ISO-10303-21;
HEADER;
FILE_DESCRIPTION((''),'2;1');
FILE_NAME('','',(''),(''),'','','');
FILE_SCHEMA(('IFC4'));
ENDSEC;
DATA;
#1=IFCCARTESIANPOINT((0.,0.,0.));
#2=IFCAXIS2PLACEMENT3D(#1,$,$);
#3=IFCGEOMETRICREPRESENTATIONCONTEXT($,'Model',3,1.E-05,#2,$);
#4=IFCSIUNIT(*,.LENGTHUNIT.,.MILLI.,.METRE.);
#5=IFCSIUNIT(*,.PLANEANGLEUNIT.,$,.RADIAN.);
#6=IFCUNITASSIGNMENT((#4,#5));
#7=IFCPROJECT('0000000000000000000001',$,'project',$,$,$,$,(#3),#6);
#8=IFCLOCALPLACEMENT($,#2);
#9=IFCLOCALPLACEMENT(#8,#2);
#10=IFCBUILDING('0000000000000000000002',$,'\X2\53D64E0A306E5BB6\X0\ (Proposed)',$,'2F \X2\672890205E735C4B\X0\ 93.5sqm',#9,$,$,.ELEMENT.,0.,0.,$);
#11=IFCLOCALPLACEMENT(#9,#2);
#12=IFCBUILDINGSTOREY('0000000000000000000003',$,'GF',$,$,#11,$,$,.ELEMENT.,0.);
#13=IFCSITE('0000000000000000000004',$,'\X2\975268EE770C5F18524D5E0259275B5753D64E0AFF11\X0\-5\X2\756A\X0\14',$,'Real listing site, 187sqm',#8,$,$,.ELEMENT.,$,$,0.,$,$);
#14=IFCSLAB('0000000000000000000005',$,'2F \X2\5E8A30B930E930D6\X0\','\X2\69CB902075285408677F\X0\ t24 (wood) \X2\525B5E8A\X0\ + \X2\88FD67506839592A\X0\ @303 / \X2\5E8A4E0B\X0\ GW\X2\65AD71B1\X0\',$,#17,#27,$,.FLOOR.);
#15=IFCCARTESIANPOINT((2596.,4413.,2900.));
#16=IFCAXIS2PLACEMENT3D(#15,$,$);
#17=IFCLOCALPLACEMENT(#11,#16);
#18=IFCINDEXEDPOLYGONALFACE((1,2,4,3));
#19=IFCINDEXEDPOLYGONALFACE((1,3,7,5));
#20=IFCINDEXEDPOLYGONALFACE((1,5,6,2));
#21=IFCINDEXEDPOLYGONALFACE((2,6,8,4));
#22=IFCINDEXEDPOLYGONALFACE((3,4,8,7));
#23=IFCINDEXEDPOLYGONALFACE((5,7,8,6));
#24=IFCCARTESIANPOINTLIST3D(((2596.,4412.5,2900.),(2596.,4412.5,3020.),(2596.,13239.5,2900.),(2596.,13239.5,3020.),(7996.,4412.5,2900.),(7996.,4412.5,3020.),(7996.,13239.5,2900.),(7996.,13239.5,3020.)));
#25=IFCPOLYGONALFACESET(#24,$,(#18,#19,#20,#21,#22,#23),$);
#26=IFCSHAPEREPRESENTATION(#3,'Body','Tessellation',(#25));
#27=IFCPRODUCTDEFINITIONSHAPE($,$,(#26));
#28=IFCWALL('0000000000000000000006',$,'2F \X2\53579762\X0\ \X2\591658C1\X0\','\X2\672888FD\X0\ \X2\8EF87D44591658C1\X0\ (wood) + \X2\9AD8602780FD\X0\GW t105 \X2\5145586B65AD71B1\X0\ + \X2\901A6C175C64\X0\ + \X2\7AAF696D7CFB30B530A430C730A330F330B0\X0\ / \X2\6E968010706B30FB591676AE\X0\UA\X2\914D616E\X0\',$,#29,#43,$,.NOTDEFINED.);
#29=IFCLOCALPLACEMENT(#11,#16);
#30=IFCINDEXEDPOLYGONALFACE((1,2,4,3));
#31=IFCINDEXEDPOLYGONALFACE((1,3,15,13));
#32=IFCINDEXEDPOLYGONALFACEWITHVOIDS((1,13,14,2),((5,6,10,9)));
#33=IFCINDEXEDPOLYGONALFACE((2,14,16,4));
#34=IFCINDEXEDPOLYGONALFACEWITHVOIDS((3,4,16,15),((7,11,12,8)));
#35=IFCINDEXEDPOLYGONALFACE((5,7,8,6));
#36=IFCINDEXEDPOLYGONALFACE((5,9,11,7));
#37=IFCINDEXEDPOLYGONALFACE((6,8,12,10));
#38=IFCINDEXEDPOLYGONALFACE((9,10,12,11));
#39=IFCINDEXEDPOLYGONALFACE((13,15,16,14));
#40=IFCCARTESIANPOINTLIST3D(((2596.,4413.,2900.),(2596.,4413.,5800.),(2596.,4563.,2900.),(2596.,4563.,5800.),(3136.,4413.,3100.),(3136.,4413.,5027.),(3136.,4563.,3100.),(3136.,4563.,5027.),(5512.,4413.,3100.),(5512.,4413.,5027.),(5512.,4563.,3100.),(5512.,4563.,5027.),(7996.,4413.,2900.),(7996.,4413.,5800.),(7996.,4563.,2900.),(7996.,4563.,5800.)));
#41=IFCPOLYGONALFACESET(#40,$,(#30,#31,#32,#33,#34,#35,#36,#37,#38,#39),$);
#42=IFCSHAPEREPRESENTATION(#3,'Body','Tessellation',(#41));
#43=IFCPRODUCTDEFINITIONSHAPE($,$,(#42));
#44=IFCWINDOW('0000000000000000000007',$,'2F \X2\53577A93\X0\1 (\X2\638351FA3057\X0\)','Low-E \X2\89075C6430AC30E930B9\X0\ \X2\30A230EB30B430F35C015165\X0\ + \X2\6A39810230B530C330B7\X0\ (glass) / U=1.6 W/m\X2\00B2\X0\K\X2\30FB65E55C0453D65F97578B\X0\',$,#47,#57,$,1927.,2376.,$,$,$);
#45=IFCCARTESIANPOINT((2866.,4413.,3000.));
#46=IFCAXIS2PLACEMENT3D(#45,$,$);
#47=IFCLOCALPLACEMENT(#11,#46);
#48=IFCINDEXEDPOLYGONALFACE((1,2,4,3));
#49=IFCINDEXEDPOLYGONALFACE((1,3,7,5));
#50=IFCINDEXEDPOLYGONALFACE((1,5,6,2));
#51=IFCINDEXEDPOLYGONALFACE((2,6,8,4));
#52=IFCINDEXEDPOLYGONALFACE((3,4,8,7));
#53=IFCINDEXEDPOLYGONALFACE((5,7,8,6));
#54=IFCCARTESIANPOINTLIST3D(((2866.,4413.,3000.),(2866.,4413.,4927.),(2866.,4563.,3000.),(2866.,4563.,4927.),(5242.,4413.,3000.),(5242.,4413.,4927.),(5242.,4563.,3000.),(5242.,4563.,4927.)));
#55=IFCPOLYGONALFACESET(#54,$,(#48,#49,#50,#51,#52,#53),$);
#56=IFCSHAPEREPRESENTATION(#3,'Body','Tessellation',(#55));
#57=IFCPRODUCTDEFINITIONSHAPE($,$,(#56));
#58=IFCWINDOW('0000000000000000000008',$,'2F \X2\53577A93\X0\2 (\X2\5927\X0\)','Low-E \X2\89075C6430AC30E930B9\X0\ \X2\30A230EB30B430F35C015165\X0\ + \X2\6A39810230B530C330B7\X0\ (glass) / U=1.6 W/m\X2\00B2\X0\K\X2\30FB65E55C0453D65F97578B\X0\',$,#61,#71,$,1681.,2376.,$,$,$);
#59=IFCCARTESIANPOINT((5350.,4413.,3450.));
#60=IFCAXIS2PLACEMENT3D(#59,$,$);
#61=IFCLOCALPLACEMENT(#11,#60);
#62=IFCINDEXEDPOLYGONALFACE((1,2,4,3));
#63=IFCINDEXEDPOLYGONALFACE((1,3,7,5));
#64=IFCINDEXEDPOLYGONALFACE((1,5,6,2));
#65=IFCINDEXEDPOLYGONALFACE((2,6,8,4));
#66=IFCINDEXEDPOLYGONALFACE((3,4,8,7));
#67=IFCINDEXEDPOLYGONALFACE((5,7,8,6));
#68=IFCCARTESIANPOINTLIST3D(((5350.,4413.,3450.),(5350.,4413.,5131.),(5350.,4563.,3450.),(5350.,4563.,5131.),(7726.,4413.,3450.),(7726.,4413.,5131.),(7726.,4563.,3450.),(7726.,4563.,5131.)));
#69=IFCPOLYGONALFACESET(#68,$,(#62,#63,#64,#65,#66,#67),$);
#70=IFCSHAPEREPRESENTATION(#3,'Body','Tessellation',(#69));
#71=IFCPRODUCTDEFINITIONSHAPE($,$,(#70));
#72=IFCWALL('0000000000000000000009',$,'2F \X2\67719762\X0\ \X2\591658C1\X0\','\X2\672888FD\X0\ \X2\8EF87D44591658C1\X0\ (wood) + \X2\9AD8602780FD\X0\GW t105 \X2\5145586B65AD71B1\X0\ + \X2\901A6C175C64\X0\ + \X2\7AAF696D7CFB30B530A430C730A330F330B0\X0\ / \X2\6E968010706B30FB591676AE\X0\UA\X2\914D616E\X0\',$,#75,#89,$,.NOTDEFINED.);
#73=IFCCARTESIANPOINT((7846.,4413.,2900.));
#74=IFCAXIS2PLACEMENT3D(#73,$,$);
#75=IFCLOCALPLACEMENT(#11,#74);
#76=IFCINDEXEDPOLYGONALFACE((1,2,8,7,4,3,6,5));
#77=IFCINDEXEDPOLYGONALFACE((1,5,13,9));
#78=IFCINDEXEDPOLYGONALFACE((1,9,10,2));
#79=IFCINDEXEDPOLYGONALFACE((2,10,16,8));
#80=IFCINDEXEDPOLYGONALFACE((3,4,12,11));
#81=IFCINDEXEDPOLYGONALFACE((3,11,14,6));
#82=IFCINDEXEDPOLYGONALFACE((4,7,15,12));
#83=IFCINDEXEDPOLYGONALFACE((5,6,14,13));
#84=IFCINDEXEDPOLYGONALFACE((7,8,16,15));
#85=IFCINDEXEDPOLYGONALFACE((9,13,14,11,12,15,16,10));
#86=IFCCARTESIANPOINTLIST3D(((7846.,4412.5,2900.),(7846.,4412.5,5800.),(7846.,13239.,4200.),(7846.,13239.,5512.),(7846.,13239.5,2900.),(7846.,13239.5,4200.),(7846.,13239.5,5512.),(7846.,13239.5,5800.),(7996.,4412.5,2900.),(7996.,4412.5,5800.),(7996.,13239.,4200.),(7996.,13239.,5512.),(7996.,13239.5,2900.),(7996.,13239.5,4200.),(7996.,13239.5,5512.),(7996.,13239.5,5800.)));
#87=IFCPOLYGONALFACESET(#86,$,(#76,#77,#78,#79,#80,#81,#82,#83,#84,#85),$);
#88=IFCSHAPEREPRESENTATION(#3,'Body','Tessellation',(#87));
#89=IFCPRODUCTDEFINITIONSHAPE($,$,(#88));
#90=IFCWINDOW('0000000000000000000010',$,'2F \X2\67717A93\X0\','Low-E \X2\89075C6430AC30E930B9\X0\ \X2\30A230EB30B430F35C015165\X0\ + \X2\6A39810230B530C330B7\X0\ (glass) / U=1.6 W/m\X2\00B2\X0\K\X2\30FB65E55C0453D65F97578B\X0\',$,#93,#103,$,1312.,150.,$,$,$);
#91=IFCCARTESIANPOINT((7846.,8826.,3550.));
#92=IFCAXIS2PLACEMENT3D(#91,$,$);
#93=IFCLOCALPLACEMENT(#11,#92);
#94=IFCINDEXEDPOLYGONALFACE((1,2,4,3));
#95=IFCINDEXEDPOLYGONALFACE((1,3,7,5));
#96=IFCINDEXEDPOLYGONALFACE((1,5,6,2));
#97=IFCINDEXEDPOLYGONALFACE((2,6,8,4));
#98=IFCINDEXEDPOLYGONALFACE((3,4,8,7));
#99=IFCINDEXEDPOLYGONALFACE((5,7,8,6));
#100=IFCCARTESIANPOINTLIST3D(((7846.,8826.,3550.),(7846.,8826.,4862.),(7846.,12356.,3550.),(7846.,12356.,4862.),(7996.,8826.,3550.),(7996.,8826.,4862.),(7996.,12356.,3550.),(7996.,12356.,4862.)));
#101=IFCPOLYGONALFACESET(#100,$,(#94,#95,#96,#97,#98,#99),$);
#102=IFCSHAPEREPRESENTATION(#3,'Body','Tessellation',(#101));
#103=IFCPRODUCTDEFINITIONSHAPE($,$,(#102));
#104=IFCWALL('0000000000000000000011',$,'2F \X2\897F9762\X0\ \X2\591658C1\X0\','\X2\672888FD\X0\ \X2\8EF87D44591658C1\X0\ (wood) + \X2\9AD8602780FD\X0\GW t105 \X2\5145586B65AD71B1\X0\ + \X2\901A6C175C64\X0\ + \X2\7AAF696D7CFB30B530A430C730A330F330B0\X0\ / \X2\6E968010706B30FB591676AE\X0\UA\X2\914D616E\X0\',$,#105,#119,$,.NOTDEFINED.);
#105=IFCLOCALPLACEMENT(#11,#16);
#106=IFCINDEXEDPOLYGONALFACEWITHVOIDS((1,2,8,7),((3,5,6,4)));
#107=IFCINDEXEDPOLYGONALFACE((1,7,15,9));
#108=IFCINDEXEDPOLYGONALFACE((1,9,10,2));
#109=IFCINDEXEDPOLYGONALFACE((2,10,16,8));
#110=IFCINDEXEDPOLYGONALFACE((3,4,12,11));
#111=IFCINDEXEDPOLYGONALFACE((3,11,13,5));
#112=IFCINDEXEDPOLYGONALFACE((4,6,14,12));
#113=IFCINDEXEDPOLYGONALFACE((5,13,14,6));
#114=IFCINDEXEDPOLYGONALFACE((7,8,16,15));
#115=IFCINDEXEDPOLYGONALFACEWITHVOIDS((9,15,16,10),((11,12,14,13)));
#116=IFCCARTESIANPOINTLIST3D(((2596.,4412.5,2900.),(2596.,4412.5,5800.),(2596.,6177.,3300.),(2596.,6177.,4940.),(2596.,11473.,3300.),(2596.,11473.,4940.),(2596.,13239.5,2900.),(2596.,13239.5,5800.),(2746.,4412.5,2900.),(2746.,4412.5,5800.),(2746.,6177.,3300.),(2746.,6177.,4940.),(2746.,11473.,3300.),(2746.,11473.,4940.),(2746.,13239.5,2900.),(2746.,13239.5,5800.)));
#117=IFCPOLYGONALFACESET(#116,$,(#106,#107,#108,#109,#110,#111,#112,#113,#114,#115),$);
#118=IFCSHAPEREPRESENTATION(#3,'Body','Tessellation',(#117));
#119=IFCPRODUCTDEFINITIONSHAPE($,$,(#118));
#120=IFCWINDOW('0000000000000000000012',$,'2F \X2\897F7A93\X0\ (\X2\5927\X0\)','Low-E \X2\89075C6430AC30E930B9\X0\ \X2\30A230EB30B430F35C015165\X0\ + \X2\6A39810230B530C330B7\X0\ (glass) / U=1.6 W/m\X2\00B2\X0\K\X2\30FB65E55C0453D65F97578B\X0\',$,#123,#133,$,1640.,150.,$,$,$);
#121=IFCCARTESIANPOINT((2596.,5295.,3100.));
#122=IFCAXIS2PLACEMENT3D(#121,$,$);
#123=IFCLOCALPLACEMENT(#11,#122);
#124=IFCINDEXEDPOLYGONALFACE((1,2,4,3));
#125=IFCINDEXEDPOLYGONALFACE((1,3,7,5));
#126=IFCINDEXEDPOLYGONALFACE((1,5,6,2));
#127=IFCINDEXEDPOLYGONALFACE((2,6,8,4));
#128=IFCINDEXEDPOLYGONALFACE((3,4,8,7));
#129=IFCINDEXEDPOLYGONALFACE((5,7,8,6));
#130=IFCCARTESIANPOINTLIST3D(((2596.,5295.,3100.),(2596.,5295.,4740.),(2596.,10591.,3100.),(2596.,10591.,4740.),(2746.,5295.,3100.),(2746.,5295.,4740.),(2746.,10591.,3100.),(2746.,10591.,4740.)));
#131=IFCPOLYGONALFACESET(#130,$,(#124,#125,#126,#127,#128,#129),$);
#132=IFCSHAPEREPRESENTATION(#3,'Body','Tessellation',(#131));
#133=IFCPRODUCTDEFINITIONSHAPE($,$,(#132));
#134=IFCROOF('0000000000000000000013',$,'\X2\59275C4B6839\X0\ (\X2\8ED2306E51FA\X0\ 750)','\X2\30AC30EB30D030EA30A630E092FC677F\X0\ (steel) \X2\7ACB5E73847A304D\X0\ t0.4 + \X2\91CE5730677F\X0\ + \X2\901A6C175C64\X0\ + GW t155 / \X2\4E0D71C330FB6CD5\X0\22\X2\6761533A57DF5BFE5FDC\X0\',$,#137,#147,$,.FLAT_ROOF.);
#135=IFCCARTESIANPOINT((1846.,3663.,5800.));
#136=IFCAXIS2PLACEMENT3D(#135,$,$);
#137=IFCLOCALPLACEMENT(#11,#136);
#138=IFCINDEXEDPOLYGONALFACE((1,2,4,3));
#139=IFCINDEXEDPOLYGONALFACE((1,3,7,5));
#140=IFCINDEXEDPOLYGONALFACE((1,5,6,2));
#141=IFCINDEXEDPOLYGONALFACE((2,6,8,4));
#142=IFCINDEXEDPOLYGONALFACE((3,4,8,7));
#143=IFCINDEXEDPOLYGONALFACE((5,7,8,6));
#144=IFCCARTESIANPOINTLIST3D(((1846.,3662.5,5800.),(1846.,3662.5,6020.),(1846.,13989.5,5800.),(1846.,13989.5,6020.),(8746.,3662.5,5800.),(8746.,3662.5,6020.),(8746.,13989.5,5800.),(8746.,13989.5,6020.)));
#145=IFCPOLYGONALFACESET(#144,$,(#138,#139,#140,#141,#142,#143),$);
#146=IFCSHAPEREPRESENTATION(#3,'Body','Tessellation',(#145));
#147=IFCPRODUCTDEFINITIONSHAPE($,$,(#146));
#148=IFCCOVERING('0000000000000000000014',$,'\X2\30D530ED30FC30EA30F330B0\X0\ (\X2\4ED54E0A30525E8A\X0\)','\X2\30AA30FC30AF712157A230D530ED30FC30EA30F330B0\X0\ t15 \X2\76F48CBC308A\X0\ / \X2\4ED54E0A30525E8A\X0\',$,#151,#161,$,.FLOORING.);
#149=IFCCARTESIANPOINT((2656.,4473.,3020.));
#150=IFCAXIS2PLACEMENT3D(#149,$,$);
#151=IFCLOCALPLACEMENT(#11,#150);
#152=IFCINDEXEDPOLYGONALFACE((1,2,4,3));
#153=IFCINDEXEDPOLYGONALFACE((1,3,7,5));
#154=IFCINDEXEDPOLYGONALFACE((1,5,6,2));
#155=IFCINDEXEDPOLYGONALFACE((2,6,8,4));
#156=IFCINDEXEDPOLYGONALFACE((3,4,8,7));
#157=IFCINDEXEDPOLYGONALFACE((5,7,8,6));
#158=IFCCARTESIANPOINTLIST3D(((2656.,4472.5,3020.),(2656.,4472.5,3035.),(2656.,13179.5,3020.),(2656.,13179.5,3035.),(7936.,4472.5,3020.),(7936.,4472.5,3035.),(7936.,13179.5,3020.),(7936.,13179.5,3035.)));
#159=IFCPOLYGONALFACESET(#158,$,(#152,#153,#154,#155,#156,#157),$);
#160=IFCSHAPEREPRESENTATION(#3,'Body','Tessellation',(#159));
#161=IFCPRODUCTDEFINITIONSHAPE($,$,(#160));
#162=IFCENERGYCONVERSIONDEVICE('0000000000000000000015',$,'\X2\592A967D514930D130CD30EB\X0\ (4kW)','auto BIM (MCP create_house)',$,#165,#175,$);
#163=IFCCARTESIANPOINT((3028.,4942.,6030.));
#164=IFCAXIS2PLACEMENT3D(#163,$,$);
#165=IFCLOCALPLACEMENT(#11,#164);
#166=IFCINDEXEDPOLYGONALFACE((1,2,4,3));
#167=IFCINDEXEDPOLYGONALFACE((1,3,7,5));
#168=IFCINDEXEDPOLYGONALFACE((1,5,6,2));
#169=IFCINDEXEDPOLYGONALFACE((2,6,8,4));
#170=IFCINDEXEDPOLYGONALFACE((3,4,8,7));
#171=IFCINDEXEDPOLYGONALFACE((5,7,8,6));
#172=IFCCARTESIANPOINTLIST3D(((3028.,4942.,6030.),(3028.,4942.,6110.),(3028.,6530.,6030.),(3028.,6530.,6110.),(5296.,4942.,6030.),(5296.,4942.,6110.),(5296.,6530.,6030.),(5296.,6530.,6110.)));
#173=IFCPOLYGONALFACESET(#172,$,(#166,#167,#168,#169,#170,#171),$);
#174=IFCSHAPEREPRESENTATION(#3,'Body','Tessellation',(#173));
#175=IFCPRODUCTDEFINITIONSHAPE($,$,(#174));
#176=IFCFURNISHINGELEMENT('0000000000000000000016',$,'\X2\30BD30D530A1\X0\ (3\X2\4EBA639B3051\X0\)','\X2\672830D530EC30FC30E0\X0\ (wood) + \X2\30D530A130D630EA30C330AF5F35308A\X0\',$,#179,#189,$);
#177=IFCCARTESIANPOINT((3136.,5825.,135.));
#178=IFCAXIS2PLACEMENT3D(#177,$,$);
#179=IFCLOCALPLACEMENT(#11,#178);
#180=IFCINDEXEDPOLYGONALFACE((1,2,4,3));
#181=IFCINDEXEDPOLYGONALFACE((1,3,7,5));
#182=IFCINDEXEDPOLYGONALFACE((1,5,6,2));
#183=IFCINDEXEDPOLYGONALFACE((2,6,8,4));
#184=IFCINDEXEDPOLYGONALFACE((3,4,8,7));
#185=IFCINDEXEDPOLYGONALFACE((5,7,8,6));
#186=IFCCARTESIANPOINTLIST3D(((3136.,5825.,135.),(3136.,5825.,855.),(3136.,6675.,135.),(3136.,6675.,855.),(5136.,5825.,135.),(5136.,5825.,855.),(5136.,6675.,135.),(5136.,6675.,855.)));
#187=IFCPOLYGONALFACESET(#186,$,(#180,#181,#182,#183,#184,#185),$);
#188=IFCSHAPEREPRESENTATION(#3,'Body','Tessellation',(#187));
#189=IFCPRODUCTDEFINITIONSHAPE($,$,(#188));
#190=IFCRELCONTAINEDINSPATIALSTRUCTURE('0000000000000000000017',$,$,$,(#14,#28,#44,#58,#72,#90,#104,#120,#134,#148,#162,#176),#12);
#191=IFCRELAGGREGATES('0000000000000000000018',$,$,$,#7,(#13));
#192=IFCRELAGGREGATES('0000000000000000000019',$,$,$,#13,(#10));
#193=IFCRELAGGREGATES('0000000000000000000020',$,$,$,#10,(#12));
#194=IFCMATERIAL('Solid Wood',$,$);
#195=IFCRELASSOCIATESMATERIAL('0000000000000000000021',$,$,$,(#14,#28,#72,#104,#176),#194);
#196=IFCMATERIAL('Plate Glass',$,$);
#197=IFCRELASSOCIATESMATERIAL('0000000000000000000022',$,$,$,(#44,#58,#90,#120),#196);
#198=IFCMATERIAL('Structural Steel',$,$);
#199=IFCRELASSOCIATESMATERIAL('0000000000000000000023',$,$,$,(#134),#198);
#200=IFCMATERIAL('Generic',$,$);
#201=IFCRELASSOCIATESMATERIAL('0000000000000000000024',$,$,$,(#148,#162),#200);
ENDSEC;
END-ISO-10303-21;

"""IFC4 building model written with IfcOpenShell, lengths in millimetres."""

from ifc_helpers import new_model, si_unit, frame, frame_2d, origin, place, context, project, spatial, rectangle, extrude, material, element, fill, save


model = new_model("IFC4")

# Units and contexts
model_context = context("Model", 3, precision=1e-05, world=origin())
ifc_project = project(units=[si_unit("LENGTHUNIT", "METRE", prefix="MILLI"), si_unit("PLANEANGLEUNIT", "RADIAN")], contexts=[model_context])

# Site, building, storey
site_placement = place(None, origin())
site = spatial("IfcSite", under=ifc_project, at=site_placement, Name="青森県弘前市大字取上１-5番14", ObjectType="Real listing site, 187sqm", CompositionType="ELEMENT", RefElevation=0.0)
building_placement = place(site_placement, origin())
building = spatial("IfcBuilding", under=site, at=building_placement, Name="取上の家 (Proposed)", ObjectType="2F 木造平屋 93.5sqm", CompositionType="ELEMENT", ElevationOfRefHeight=0.0, ElevationOfTerrain=0.0)
storey_placement = place(building_placement, origin())
storey = spatial("IfcBuildingStorey", under=building, at=storey_placement, Name="GF", CompositionType="ELEMENT", Elevation=0.0)

# Slab
ifc_material_1 = material(Name="Solid Wood")
slab_placement = place(storey_placement, frame((2596.0, 4413.0, 2900.0)))
element("IfcSlab", 1, at=slab_placement, inside=storey, material=ifc_material_1, Name="2F 床スラブ", Description="構造用合板 t24 (wood) 剛床 + 製材根太 @303 / 床下 GW断熱", PredefinedType="FLOOR", context=model_context, shape_type="SweptSolid", body=[
    extrude(rectangle(XDim=5400.0, YDim=8827.0, at=frame_2d((2700.0, 4413.0))), frame((2596.0, 4413.0, 2900.0)), (0.0, 0.0, 1.0), 120.0),
])

# Wall, openings, windows
wall_1_placement = place(storey_placement, frame((2596.0, 4413.0, 2900.0)))
wall_1 = element("IfcWall", 2, at=wall_1_placement, inside=storey, material=ifc_material_1, Name="2F 南面 外壁", Description="木製 軸組外壁 (wood) + 高性能GW t105 充填断熱 + 通気層 + 窯業系サイディング / 準耐火・外皮UA配慮", PredefinedType="NOTDEFINED", context=model_context, shape_type="SweptSolid", body=[
    extrude(rectangle(XDim=5400.0, YDim=150.0, at=frame_2d((2700.0, 75.0))), frame((2596.0, 4413.0, 2900.0)), (0.0, 0.0, 1.0), 2900.0),
])
opening_1_placement = place(storey_placement, frame((2866.0, 4413.0, 3000.0)))
opening_1 = element("IfcOpeningElement", 3, at=opening_1_placement, cuts=wall_1, PredefinedType="NOTDEFINED", context=model_context, shape_type="SweptSolid", body=[
    extrude(rectangle(XDim=2376.0, YDim=150.0, at=frame_2d((1188.0, 75.0))), frame((2866.0, 4413.0, 3000.0)), (0.0, 0.0, 1.0), 1927.0),
])
opening_2_placement = place(storey_placement, frame((5350.0, 4413.0, 3450.0)))
opening_2 = element("IfcOpeningElement", 4, at=opening_2_placement, cuts=wall_1, PredefinedType="NOTDEFINED", context=model_context, shape_type="SweptSolid", body=[
    extrude(rectangle(XDim=2376.0, YDim=150.0, at=frame_2d((1188.0, 75.0))), frame((5350.0, 4413.0, 3450.0)), (0.0, 0.0, 1.0), 1681.0),
])
ifc_material_2 = material(Name="Plate Glass")
window_1_placement = place(storey_placement, frame((2866.0, 4413.0, 3000.0)))
window_1 = element("IfcWindow", 5, at=window_1_placement, inside=storey, material=ifc_material_2, Name="2F 南窓1 (掃出し)", Description="Low-E 複層ガラス アルゴン封入 + 樹脂サッシ (glass) / U=1.6 W/m²K・日射取得型", OverallHeight=1927.0, OverallWidth=2376.0, context=model_context, shape_type="SweptSolid", body=[
    extrude(rectangle(XDim=2376.0, YDim=150.0, at=frame_2d((1188.0, 75.0))), frame((2866.0, 4413.0, 3000.0)), (0.0, 0.0, 1.0), 1927.0),
])
fill(opening_1, window_1)
window_2_placement = place(storey_placement, frame((5350.0, 4413.0, 3450.0)))
window_2 = element("IfcWindow", 6, at=window_2_placement, inside=storey, material=ifc_material_2, Name="2F 南窓2 (大)", Description="Low-E 複層ガラス アルゴン封入 + 樹脂サッシ (glass) / U=1.6 W/m²K・日射取得型", OverallHeight=1681.0, OverallWidth=2376.0, context=model_context, shape_type="SweptSolid", body=[
    extrude(rectangle(XDim=2376.0, YDim=150.0, at=frame_2d((1188.0, 75.0))), frame((5350.0, 4413.0, 3450.0)), (0.0, 0.0, 1.0), 1681.0),
])
fill(opening_2, window_2)

# Walls, openings, windows
wall_2_placement = place(storey_placement, frame((7846.0, 4413.0, 2900.0)))
wall_2 = element("IfcWall", 7, at=wall_2_placement, inside=storey, material=ifc_material_1, Name="2F 東面 外壁", Description="木製 軸組外壁 (wood) + 高性能GW t105 充填断熱 + 通気層 + 窯業系サイディング / 準耐火・外皮UA配慮", PredefinedType="NOTDEFINED", context=model_context, shape_type="SweptSolid", body=[
    extrude(rectangle(XDim=150.0, YDim=8827.0, at=frame_2d((75.0, 4413.0))), frame((7846.0, 4413.0, 2900.0)), (0.0, 0.0, 1.0), 2900.0),
])
opening_3_placement = place(storey_placement, frame((7846.0, 8826.0, 3550.0)))
opening_3 = element("IfcOpeningElement", 8, at=opening_3_placement, cuts=wall_2, PredefinedType="NOTDEFINED", context=model_context, shape_type="SweptSolid", body=[
    extrude(rectangle(XDim=150.0, YDim=3530.0, at=frame_2d((75.0, 1765.0))), frame((7846.0, 8826.0, 3550.0)), (0.0, 0.0, 1.0), 1312.0),
])
window_3_placement = place(storey_placement, frame((7846.0, 8826.0, 3550.0)))
window_3 = element("IfcWindow", 9, at=window_3_placement, inside=storey, material=ifc_material_2, Name="2F 東窓", Description="Low-E 複層ガラス アルゴン封入 + 樹脂サッシ (glass) / U=1.6 W/m²K・日射取得型", OverallHeight=1312.0, OverallWidth=150.0, context=model_context, shape_type="SweptSolid", body=[
    extrude(rectangle(XDim=150.0, YDim=3530.0, at=frame_2d((75.0, 1765.0))), frame((7846.0, 8826.0, 3550.0)), (0.0, 0.0, 1.0), 1312.0),
])
fill(opening_3, window_3)
wall_3_placement = place(storey_placement, frame((2596.0, 4413.0, 2900.0)))
wall_3 = element("IfcWall", 10, at=wall_3_placement, inside=storey, material=ifc_material_1, Name="2F 西面 外壁", Description="木製 軸組外壁 (wood) + 高性能GW t105 充填断熱 + 通気層 + 窯業系サイディング / 準耐火・外皮UA配慮", PredefinedType="NOTDEFINED", context=model_context, shape_type="SweptSolid", body=[
    extrude(rectangle(XDim=150.0, YDim=8827.0, at=frame_2d((75.0, 4413.0))), frame((2596.0, 4413.0, 2900.0)), (0.0, 0.0, 1.0), 2900.0),
])
opening_4_placement = place(storey_placement, frame((2596.0, 5295.0, 3100.0)))
opening_4 = element("IfcOpeningElement", 11, at=opening_4_placement, cuts=wall_3, PredefinedType="NOTDEFINED", context=model_context, shape_type="SweptSolid", body=[
    extrude(rectangle(XDim=150.0, YDim=5296.0, at=frame_2d((75.0, 2648.0))), frame((2596.0, 5295.0, 3100.0)), (0.0, 0.0, 1.0), 1640.0),
])
window_4_placement = place(storey_placement, frame((2596.0, 5295.0, 3100.0)))
window_4 = element("IfcWindow", 12, at=window_4_placement, inside=storey, material=ifc_material_2, Name="2F 西窓 (大)", Description="Low-E 複層ガラス アルゴン封入 + 樹脂サッシ (glass) / U=1.6 W/m²K・日射取得型", OverallHeight=1640.0, OverallWidth=150.0, context=model_context, shape_type="SweptSolid", body=[
    extrude(rectangle(XDim=150.0, YDim=5296.0, at=frame_2d((75.0, 2648.0))), frame((2596.0, 5295.0, 3100.0)), (0.0, 0.0, 1.0), 1640.0),
])
fill(opening_4, window_4)

# Roof
ifc_material_3 = material(Name="Structural Steel")
roof_placement = place(storey_placement, frame((1846.0, 3663.0, 5800.0)))
element("IfcRoof", 13, at=roof_placement, inside=storey, material=ifc_material_3, Name="大屋根 (軒の出 750)", Description="ガルバリウム鋼板 (steel) 立平葺き t0.4 + 野地板 + 通気層 + GW t155 / 不燃・法22条区域対応", PredefinedType="FLAT_ROOF", context=model_context, shape_type="SweptSolid", body=[
    extrude(rectangle(XDim=6900.0, YDim=10327.0, at=frame_2d((3450.0, 5163.0))), frame((1846.0, 3663.0, 5800.0)), (0.0, 0.0, 1.0), 220.0),
])

# Covering
ifc_material_4 = material(Name="Generic")
covering_placement = place(storey_placement, frame((2656.0, 4473.0, 3020.0)))
element("IfcCovering", 14, at=covering_placement, inside=storey, material=ifc_material_4, Name="フローリング (仕上げ床)", Description="オーク無垢フローリング t15 直貼り / 仕上げ床", PredefinedType="FLOORING", context=model_context, shape_type="SweptSolid", body=[
    extrude(rectangle(XDim=5280.0, YDim=8707.0, at=frame_2d((2640.0, 4353.0))), frame((2656.0, 4473.0, 3020.0)), (0.0, 0.0, 1.0), 15.0),
])

# Energy conversion device
energy_conversion_device_placement = place(storey_placement, frame((3028.0, 4942.0, 6030.0)))
element("IfcEnergyConversionDevice", 15, at=energy_conversion_device_placement, inside=storey, material=ifc_material_4, Name="太陽光パネル (4kW)", Description="auto BIM (MCP create_house)", context=model_context, shape_type="SweptSolid", body=[
    extrude(rectangle(XDim=2268.0, YDim=1588.0, at=frame_2d((1134.0, 794.0))), frame((3028.0, 4942.0, 6030.0)), (0.0, 0.0, 1.0), 80.0),
])

# Furnishing element
furnishing_1_placement = place(storey_placement, frame((3136.0, 5825.0, 135.0)))
element("IfcFurnishingElement", 16, at=furnishing_1_placement, inside=storey, material=ifc_material_1, Name="ソファ (3人掛け)", Description="木フレーム (wood) + ファブリック張り", context=model_context, shape_type="SweptSolid", body=[
    extrude(rectangle(XDim=2000.0, YDim=850.0, at=frame_2d((1000.0, 425.0))), frame((3136.0, 5825.0, 135.0)), (0.0, 0.0, 1.0), 720.0),
])

save(model, "model.ifc")
